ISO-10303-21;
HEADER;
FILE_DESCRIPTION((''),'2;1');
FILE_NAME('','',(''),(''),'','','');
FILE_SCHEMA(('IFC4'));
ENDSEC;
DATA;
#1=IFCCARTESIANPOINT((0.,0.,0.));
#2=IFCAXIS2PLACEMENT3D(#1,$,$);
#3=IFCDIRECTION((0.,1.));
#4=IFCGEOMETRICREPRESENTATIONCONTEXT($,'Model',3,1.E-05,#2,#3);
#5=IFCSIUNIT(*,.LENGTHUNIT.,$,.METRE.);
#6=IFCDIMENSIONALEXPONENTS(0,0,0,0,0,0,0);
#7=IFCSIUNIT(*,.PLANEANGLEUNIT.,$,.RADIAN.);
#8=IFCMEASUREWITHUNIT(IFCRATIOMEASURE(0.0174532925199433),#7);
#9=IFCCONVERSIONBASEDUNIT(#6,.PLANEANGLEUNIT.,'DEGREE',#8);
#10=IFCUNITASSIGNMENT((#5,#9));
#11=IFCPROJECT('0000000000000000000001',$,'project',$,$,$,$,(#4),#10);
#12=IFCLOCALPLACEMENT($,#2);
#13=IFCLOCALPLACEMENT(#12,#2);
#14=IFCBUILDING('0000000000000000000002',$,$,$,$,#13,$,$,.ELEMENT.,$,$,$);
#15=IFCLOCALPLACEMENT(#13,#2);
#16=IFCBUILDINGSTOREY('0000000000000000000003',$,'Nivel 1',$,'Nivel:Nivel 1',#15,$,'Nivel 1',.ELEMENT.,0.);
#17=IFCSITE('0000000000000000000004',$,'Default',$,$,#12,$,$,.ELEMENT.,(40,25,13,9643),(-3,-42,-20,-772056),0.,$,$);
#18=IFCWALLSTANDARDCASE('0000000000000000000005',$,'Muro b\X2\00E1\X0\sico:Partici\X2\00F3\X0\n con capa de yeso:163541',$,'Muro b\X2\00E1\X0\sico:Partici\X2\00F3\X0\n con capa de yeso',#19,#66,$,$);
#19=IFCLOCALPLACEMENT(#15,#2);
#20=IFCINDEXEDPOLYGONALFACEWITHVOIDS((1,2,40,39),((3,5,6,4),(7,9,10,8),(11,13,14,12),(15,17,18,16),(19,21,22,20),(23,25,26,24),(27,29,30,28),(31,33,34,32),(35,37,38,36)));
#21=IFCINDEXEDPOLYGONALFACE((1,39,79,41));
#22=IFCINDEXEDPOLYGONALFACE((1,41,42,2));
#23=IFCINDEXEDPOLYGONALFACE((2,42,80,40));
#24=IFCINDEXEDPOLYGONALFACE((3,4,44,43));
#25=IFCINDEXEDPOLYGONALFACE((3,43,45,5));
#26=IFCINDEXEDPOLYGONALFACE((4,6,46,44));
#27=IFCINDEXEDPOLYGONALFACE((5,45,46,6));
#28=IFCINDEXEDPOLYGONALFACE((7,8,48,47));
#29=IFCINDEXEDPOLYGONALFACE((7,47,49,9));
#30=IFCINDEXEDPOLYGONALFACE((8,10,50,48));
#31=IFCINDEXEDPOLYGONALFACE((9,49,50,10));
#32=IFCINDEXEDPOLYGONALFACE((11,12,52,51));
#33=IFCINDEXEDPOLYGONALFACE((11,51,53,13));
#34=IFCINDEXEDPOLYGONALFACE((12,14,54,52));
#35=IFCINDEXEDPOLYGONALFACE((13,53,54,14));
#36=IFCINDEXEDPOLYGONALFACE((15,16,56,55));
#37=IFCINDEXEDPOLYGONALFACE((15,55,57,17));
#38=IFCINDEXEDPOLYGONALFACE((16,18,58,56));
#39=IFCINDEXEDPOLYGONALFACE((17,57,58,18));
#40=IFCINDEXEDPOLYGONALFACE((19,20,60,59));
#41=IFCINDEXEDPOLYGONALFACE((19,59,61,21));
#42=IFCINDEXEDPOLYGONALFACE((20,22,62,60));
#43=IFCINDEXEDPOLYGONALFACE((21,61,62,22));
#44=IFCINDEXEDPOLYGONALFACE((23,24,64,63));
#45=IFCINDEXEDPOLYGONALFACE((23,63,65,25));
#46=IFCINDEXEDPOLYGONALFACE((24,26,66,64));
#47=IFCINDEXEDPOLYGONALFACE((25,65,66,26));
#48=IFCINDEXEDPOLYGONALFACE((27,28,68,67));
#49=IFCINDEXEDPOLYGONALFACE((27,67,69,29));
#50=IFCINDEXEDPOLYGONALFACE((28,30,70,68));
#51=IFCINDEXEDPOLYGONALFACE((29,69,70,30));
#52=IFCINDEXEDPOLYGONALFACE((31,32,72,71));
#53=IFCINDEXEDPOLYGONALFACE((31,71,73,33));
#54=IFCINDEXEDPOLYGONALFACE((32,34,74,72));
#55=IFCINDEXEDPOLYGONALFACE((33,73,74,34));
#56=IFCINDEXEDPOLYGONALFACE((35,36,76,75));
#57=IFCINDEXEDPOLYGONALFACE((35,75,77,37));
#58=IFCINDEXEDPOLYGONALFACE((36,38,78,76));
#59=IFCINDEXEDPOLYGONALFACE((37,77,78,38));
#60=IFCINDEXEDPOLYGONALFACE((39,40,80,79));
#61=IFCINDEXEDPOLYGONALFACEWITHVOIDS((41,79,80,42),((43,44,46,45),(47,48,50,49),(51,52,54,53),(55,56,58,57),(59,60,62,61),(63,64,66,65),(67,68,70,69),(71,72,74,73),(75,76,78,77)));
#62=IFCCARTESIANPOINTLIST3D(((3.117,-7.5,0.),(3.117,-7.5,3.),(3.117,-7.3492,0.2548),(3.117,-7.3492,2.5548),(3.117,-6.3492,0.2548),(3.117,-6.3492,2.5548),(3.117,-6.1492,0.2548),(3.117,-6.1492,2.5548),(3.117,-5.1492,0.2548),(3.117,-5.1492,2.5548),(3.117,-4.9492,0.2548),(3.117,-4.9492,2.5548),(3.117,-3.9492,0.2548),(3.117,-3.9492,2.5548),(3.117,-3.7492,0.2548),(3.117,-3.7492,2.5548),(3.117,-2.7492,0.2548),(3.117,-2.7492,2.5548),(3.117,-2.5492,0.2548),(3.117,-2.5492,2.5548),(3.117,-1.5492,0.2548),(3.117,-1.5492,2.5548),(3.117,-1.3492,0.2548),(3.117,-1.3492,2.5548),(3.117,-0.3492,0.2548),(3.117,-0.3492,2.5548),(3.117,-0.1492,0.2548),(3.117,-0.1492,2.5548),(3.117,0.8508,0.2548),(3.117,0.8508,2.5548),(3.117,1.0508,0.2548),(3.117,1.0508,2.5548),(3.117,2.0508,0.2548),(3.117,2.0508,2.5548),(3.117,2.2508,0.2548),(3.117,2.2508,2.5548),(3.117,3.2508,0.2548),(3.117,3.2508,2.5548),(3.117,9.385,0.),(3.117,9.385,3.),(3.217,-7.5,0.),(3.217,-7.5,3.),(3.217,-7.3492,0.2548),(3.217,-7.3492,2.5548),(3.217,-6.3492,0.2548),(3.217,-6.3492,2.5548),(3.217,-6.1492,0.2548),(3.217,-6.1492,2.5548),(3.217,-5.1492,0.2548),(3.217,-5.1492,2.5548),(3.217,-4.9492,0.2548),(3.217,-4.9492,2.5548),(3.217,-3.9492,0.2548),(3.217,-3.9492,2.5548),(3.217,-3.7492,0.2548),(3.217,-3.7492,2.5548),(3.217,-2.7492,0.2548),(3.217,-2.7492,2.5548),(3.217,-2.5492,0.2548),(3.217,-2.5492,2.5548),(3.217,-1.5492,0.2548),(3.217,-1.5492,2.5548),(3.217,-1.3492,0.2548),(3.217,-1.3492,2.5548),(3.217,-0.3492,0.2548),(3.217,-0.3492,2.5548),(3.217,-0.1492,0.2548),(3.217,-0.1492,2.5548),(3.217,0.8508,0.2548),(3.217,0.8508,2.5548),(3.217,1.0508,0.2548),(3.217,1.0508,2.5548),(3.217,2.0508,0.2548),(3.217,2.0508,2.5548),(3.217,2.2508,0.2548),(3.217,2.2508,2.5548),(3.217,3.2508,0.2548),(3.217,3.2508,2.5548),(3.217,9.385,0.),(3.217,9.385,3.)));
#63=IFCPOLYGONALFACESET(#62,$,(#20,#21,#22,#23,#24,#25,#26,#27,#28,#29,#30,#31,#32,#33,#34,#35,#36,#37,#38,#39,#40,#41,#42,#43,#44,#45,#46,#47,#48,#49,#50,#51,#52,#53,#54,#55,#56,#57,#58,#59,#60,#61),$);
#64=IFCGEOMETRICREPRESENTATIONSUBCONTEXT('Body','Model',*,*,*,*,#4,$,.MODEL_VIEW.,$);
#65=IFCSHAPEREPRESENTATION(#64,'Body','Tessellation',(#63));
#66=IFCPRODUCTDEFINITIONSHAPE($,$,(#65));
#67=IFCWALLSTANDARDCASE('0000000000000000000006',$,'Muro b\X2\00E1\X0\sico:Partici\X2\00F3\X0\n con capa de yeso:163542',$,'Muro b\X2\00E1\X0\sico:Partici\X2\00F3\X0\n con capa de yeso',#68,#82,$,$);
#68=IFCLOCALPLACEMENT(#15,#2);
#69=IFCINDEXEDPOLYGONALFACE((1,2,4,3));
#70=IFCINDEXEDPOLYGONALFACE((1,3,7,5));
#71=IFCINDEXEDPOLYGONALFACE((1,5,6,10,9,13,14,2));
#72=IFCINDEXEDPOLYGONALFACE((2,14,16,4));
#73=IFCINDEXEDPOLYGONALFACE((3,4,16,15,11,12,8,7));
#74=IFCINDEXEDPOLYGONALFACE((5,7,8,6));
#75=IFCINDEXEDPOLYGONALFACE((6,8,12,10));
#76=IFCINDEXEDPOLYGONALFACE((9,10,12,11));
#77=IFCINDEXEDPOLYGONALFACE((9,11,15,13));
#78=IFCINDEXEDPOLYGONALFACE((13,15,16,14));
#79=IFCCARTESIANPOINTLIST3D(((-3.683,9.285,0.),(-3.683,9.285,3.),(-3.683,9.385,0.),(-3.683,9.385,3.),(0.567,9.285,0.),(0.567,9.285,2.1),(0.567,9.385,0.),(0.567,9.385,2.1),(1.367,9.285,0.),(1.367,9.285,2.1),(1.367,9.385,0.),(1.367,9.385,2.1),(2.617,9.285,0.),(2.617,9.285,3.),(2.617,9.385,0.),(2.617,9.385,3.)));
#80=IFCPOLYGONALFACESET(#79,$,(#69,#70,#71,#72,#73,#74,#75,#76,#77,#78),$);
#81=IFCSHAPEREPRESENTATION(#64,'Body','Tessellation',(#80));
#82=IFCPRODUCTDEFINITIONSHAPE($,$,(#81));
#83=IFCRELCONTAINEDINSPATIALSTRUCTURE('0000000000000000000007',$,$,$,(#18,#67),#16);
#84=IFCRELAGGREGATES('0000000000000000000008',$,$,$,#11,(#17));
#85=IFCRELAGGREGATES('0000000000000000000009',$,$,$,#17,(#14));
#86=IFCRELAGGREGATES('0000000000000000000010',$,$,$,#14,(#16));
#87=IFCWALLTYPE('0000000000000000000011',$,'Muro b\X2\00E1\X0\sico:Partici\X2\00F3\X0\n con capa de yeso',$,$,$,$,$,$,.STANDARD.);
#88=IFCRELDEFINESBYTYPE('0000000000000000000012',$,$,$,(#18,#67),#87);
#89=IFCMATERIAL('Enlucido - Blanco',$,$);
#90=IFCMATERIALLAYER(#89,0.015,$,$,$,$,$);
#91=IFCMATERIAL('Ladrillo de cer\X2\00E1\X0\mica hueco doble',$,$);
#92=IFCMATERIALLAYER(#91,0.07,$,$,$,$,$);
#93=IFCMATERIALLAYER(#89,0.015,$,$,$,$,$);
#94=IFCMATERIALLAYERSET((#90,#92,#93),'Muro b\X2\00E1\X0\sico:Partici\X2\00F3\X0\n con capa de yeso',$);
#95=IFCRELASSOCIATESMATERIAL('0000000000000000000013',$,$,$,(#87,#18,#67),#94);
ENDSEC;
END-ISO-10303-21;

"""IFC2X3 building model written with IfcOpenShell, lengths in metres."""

from ifc_helpers import new_model, entity, si_unit, converted_unit, direction, frame, frame_2d, origin, place, context, subcontext, project, spatial, rectangle, extrude, material, layer, layer_set, layer_usage, type_object, element, save


model = new_model("IFC2X3")

# Units and contexts
model_context = context("Model", 3, precision=1e-05, world=origin(), true_north=direction((0.0, 1.0)))
body_context = subcontext(model_context, "Body", "Model", "MODEL_VIEW")
ifc_project = project(units=[si_unit("LENGTHUNIT", "METRE"), converted_unit("PLANEANGLEUNIT", "DEGREE", entity("IfcRatioMeasure", 0.0174532925199433), si_unit("PLANEANGLEUNIT", "RADIAN"), dimensions=[0, 0, 0, 0, 0, 0, 0])], contexts=[model_context])

# Site, building, storey
site_placement = place(None, origin())
site = spatial("IfcSite", under=ifc_project, at=site_placement, Name="Default", CompositionType="ELEMENT", RefLatitude=(40, 25, 13, 9643), RefLongitude=(-3, -42, -20, -772056), RefElevation=0.0)
building_placement = place(site_placement, origin())
building = spatial("IfcBuilding", under=site, at=building_placement, CompositionType="ELEMENT")
storey_placement = place(building_placement, origin())
storey = spatial("IfcBuildingStorey", under=building, at=storey_placement, Name="Nivel 1", ObjectType="Nivel:Nivel 1", LongName="Nivel 1", CompositionType="ELEMENT", Elevation=0.0)

# Wall, openings
ifc_material_1 = material(Name="Enlucido - Blanco")
ifc_layer_1 = layer(ifc_material_1, 0.015)
ifc_material_2 = material(Name="Ladrillo de cerámica hueco doble")
ifc_layer_2 = layer(ifc_material_2, 0.07)
ifc_layer_3 = layer(ifc_material_1, 0.015)
ifc_layer_set_1 = layer_set([ifc_layer_1, ifc_layer_2, ifc_layer_3], Name="Muro básico:Partición con capa de yeso")
ifc_layer_usage_1 = layer_usage(ifc_layer_set_1, "AXIS2", "NEGATIVE", 0.05)
wall_type = type_object("IfcWallType", Name="Muro básico:Partición con capa de yeso", PredefinedType="STANDARD", material=ifc_layer_set_1)
wall_1_placement = place(storey_placement, frame((3.167, 9.385, 0.0), z_axis=(0.0, 0.0, 1.0), x_axis=(0.0, -1.0, 0.0)))
wall_1 = element("IfcWallStandardCase", 1, at=wall_1_placement, inside=storey, type_object=wall_type, material=ifc_layer_usage_1, Name="Muro básico:Partición con capa de yeso:163541", ObjectType="Muro básico:Partición con capa de yeso", context=body_context, shape_type="SweptSolid", body=[
    extrude(rectangle(XDim=16.885, YDim=0.1, at=frame_2d((8.4425, 0.0), x_axis=(-1.0, 0.0))), origin(), (0.0, 0.0, 1.0), 3.0),
])
opening_1_placement = place(wall_1_placement, frame((15.7342, -0.05, 0.2548)))
element("IfcOpeningElement", 2, at=opening_1_placement, cuts=wall_1, ObjectType="Opening", context=body_context, shape_type="SweptSolid", body=[
    extrude(rectangle(XDim=2.3, YDim=1.0, at=frame_2d((1.15, 0.5), x_axis=(1.0, 0.0))), frame((0.0, 0.0, 0.0), z_axis=(0.0, 1.0, 0.0), x_axis=(0.0, 0.0, 1.0)), (0.0, 0.0, 1.0), 0.1),
])
opening_2_placement = place(wall_1_placement, frame((14.5342, -0.05, 0.2548)))
element("IfcOpeningElement", 3, at=opening_2_placement, cuts=wall_1, ObjectType="Opening", context=body_context, shape_type="SweptSolid", body=[
    extrude(rectangle(XDim=2.3, YDim=1.0, at=frame_2d((1.15, 0.5), x_axis=(1.0, 0.0))), frame((0.0, 0.0, 0.0), z_axis=(0.0, 1.0, 0.0), x_axis=(0.0, 0.0, 1.0)), (0.0, 0.0, 1.0), 0.1),
])
opening_3_placement = place(wall_1_placement, frame((13.3342, -0.05, 0.2548)))
element("IfcOpeningElement", 4, at=opening_3_placement, cuts=wall_1, ObjectType="Opening", context=body_context, shape_type="SweptSolid", body=[
    extrude(rectangle(XDim=2.3, YDim=1.0, at=frame_2d((1.15, 0.5), x_axis=(1.0, 0.0))), frame((0.0, 0.0, 0.0), z_axis=(0.0, 1.0, 0.0), x_axis=(0.0, 0.0, 1.0)), (0.0, 0.0, 1.0), 0.1),
])
opening_4_placement = place(wall_1_placement, frame((12.1342, -0.05, 0.2548)))
element("IfcOpeningElement", 5, at=opening_4_placement, cuts=wall_1, ObjectType="Opening", context=body_context, shape_type="SweptSolid", body=[
    extrude(rectangle(XDim=2.3, YDim=1.0, at=frame_2d((1.15, 0.5), x_axis=(1.0, 0.0))), frame((0.0, 0.0, 0.0), z_axis=(0.0, 1.0, 0.0), x_axis=(0.0, 0.0, 1.0)), (0.0, 0.0, 1.0), 0.1),
])
opening_5_placement = place(wall_1_placement, frame((10.9342, -0.05, 0.2548)))
element("IfcOpeningElement", 6, at=opening_5_placement, cuts=wall_1, ObjectType="Opening", context=body_context, shape_type="SweptSolid", body=[
    extrude(rectangle(XDim=2.3, YDim=1.0, at=frame_2d((1.15, 0.5), x_axis=(1.0, 0.0))), frame((0.0, 0.0, 0.0), z_axis=(0.0, 1.0, 0.0), x_axis=(0.0, 0.0, 1.0)), (0.0, 0.0, 1.0), 0.1),
])
opening_6_placement = place(wall_1_placement, frame((9.7342, -0.05, 0.2548)))
element("IfcOpeningElement", 7, at=opening_6_placement, cuts=wall_1, ObjectType="Opening", context=body_context, shape_type="SweptSolid", body=[
    extrude(rectangle(XDim=2.3, YDim=1.0, at=frame_2d((1.15, 0.5), x_axis=(1.0, 0.0))), frame((0.0, 0.0, 0.0), z_axis=(0.0, 1.0, 0.0), x_axis=(0.0, 0.0, 1.0)), (0.0, 0.0, 1.0), 0.1),
])
opening_7_placement = place(wall_1_placement, frame((8.5342, -0.05, 0.2548)))
element("IfcOpeningElement", 8, at=opening_7_placement, cuts=wall_1, ObjectType="Opening", context=body_context, shape_type="SweptSolid", body=[
    extrude(rectangle(XDim=2.3, YDim=1.0, at=frame_2d((1.15, 0.5), x_axis=(1.0, 0.0))), frame((0.0, 0.0, 0.0), z_axis=(0.0, 1.0, 0.0), x_axis=(0.0, 0.0, 1.0)), (0.0, 0.0, 1.0), 0.1),
])
opening_8_placement = place(wall_1_placement, frame((7.3342, -0.05, 0.2548)))
element("IfcOpeningElement", 9, at=opening_8_placement, cuts=wall_1, ObjectType="Opening", context=body_context, shape_type="SweptSolid", body=[
    extrude(rectangle(XDim=2.3, YDim=1.0, at=frame_2d((1.15, 0.5), x_axis=(1.0, 0.0))), frame((0.0, 0.0, 0.0), z_axis=(0.0, 1.0, 0.0), x_axis=(0.0, 0.0, 1.0)), (0.0, 0.0, 1.0), 0.1),
])
opening_9_placement = place(wall_1_placement, frame((6.1342, -0.05, 0.2548)))
element("IfcOpeningElement", 10, at=opening_9_placement, cuts=wall_1, ObjectType="Opening", context=body_context, shape_type="SweptSolid", body=[
    extrude(rectangle(XDim=2.3, YDim=1.0, at=frame_2d((1.15, 0.5), x_axis=(1.0, 0.0))), frame((0.0, 0.0, 0.0), z_axis=(0.0, 1.0, 0.0), x_axis=(0.0, 0.0, 1.0)), (0.0, 0.0, 1.0), 0.1),
])

# Wall, opening
ifc_layer_usage_2 = layer_usage(ifc_layer_set_1, "AXIS2", "NEGATIVE", 0.05)
wall_2_placement = place(storey_placement, frame((-4.183, 9.335, 0.0)))
wall_2 = element("IfcWallStandardCase", 11, at=wall_2_placement, inside=storey, type_object=wall_type, material=ifc_layer_usage_2, Name="Muro básico:Partición con capa de yeso:163542", ObjectType="Muro básico:Partición con capa de yeso", context=body_context, shape_type="SweptSolid", body=[
    extrude(rectangle(XDim=6.3, YDim=0.1, at=frame_2d((3.65, 0.0), x_axis=(-1.0, 0.0))), origin(), (0.0, 0.0, 1.0), 3.0),
])
opening_10_placement = place(wall_2_placement, frame((5.55, 0.05, 0.0)))
element("IfcOpeningElement", 12, at=opening_10_placement, cuts=wall_2, ObjectType="Opening", context=body_context, shape_type="SweptSolid", body=[
    extrude(rectangle(XDim=2.1, YDim=0.8, at=frame_2d((1.05, 0.4), x_axis=(1.0, 0.0))), frame((0.0, 0.0, 0.0), z_axis=(0.0, -1.0, 0.0), x_axis=(0.0, 0.0, 1.0)), (0.0, 0.0, 1.0), 0.1),
])

save(model, "model.ifc")
